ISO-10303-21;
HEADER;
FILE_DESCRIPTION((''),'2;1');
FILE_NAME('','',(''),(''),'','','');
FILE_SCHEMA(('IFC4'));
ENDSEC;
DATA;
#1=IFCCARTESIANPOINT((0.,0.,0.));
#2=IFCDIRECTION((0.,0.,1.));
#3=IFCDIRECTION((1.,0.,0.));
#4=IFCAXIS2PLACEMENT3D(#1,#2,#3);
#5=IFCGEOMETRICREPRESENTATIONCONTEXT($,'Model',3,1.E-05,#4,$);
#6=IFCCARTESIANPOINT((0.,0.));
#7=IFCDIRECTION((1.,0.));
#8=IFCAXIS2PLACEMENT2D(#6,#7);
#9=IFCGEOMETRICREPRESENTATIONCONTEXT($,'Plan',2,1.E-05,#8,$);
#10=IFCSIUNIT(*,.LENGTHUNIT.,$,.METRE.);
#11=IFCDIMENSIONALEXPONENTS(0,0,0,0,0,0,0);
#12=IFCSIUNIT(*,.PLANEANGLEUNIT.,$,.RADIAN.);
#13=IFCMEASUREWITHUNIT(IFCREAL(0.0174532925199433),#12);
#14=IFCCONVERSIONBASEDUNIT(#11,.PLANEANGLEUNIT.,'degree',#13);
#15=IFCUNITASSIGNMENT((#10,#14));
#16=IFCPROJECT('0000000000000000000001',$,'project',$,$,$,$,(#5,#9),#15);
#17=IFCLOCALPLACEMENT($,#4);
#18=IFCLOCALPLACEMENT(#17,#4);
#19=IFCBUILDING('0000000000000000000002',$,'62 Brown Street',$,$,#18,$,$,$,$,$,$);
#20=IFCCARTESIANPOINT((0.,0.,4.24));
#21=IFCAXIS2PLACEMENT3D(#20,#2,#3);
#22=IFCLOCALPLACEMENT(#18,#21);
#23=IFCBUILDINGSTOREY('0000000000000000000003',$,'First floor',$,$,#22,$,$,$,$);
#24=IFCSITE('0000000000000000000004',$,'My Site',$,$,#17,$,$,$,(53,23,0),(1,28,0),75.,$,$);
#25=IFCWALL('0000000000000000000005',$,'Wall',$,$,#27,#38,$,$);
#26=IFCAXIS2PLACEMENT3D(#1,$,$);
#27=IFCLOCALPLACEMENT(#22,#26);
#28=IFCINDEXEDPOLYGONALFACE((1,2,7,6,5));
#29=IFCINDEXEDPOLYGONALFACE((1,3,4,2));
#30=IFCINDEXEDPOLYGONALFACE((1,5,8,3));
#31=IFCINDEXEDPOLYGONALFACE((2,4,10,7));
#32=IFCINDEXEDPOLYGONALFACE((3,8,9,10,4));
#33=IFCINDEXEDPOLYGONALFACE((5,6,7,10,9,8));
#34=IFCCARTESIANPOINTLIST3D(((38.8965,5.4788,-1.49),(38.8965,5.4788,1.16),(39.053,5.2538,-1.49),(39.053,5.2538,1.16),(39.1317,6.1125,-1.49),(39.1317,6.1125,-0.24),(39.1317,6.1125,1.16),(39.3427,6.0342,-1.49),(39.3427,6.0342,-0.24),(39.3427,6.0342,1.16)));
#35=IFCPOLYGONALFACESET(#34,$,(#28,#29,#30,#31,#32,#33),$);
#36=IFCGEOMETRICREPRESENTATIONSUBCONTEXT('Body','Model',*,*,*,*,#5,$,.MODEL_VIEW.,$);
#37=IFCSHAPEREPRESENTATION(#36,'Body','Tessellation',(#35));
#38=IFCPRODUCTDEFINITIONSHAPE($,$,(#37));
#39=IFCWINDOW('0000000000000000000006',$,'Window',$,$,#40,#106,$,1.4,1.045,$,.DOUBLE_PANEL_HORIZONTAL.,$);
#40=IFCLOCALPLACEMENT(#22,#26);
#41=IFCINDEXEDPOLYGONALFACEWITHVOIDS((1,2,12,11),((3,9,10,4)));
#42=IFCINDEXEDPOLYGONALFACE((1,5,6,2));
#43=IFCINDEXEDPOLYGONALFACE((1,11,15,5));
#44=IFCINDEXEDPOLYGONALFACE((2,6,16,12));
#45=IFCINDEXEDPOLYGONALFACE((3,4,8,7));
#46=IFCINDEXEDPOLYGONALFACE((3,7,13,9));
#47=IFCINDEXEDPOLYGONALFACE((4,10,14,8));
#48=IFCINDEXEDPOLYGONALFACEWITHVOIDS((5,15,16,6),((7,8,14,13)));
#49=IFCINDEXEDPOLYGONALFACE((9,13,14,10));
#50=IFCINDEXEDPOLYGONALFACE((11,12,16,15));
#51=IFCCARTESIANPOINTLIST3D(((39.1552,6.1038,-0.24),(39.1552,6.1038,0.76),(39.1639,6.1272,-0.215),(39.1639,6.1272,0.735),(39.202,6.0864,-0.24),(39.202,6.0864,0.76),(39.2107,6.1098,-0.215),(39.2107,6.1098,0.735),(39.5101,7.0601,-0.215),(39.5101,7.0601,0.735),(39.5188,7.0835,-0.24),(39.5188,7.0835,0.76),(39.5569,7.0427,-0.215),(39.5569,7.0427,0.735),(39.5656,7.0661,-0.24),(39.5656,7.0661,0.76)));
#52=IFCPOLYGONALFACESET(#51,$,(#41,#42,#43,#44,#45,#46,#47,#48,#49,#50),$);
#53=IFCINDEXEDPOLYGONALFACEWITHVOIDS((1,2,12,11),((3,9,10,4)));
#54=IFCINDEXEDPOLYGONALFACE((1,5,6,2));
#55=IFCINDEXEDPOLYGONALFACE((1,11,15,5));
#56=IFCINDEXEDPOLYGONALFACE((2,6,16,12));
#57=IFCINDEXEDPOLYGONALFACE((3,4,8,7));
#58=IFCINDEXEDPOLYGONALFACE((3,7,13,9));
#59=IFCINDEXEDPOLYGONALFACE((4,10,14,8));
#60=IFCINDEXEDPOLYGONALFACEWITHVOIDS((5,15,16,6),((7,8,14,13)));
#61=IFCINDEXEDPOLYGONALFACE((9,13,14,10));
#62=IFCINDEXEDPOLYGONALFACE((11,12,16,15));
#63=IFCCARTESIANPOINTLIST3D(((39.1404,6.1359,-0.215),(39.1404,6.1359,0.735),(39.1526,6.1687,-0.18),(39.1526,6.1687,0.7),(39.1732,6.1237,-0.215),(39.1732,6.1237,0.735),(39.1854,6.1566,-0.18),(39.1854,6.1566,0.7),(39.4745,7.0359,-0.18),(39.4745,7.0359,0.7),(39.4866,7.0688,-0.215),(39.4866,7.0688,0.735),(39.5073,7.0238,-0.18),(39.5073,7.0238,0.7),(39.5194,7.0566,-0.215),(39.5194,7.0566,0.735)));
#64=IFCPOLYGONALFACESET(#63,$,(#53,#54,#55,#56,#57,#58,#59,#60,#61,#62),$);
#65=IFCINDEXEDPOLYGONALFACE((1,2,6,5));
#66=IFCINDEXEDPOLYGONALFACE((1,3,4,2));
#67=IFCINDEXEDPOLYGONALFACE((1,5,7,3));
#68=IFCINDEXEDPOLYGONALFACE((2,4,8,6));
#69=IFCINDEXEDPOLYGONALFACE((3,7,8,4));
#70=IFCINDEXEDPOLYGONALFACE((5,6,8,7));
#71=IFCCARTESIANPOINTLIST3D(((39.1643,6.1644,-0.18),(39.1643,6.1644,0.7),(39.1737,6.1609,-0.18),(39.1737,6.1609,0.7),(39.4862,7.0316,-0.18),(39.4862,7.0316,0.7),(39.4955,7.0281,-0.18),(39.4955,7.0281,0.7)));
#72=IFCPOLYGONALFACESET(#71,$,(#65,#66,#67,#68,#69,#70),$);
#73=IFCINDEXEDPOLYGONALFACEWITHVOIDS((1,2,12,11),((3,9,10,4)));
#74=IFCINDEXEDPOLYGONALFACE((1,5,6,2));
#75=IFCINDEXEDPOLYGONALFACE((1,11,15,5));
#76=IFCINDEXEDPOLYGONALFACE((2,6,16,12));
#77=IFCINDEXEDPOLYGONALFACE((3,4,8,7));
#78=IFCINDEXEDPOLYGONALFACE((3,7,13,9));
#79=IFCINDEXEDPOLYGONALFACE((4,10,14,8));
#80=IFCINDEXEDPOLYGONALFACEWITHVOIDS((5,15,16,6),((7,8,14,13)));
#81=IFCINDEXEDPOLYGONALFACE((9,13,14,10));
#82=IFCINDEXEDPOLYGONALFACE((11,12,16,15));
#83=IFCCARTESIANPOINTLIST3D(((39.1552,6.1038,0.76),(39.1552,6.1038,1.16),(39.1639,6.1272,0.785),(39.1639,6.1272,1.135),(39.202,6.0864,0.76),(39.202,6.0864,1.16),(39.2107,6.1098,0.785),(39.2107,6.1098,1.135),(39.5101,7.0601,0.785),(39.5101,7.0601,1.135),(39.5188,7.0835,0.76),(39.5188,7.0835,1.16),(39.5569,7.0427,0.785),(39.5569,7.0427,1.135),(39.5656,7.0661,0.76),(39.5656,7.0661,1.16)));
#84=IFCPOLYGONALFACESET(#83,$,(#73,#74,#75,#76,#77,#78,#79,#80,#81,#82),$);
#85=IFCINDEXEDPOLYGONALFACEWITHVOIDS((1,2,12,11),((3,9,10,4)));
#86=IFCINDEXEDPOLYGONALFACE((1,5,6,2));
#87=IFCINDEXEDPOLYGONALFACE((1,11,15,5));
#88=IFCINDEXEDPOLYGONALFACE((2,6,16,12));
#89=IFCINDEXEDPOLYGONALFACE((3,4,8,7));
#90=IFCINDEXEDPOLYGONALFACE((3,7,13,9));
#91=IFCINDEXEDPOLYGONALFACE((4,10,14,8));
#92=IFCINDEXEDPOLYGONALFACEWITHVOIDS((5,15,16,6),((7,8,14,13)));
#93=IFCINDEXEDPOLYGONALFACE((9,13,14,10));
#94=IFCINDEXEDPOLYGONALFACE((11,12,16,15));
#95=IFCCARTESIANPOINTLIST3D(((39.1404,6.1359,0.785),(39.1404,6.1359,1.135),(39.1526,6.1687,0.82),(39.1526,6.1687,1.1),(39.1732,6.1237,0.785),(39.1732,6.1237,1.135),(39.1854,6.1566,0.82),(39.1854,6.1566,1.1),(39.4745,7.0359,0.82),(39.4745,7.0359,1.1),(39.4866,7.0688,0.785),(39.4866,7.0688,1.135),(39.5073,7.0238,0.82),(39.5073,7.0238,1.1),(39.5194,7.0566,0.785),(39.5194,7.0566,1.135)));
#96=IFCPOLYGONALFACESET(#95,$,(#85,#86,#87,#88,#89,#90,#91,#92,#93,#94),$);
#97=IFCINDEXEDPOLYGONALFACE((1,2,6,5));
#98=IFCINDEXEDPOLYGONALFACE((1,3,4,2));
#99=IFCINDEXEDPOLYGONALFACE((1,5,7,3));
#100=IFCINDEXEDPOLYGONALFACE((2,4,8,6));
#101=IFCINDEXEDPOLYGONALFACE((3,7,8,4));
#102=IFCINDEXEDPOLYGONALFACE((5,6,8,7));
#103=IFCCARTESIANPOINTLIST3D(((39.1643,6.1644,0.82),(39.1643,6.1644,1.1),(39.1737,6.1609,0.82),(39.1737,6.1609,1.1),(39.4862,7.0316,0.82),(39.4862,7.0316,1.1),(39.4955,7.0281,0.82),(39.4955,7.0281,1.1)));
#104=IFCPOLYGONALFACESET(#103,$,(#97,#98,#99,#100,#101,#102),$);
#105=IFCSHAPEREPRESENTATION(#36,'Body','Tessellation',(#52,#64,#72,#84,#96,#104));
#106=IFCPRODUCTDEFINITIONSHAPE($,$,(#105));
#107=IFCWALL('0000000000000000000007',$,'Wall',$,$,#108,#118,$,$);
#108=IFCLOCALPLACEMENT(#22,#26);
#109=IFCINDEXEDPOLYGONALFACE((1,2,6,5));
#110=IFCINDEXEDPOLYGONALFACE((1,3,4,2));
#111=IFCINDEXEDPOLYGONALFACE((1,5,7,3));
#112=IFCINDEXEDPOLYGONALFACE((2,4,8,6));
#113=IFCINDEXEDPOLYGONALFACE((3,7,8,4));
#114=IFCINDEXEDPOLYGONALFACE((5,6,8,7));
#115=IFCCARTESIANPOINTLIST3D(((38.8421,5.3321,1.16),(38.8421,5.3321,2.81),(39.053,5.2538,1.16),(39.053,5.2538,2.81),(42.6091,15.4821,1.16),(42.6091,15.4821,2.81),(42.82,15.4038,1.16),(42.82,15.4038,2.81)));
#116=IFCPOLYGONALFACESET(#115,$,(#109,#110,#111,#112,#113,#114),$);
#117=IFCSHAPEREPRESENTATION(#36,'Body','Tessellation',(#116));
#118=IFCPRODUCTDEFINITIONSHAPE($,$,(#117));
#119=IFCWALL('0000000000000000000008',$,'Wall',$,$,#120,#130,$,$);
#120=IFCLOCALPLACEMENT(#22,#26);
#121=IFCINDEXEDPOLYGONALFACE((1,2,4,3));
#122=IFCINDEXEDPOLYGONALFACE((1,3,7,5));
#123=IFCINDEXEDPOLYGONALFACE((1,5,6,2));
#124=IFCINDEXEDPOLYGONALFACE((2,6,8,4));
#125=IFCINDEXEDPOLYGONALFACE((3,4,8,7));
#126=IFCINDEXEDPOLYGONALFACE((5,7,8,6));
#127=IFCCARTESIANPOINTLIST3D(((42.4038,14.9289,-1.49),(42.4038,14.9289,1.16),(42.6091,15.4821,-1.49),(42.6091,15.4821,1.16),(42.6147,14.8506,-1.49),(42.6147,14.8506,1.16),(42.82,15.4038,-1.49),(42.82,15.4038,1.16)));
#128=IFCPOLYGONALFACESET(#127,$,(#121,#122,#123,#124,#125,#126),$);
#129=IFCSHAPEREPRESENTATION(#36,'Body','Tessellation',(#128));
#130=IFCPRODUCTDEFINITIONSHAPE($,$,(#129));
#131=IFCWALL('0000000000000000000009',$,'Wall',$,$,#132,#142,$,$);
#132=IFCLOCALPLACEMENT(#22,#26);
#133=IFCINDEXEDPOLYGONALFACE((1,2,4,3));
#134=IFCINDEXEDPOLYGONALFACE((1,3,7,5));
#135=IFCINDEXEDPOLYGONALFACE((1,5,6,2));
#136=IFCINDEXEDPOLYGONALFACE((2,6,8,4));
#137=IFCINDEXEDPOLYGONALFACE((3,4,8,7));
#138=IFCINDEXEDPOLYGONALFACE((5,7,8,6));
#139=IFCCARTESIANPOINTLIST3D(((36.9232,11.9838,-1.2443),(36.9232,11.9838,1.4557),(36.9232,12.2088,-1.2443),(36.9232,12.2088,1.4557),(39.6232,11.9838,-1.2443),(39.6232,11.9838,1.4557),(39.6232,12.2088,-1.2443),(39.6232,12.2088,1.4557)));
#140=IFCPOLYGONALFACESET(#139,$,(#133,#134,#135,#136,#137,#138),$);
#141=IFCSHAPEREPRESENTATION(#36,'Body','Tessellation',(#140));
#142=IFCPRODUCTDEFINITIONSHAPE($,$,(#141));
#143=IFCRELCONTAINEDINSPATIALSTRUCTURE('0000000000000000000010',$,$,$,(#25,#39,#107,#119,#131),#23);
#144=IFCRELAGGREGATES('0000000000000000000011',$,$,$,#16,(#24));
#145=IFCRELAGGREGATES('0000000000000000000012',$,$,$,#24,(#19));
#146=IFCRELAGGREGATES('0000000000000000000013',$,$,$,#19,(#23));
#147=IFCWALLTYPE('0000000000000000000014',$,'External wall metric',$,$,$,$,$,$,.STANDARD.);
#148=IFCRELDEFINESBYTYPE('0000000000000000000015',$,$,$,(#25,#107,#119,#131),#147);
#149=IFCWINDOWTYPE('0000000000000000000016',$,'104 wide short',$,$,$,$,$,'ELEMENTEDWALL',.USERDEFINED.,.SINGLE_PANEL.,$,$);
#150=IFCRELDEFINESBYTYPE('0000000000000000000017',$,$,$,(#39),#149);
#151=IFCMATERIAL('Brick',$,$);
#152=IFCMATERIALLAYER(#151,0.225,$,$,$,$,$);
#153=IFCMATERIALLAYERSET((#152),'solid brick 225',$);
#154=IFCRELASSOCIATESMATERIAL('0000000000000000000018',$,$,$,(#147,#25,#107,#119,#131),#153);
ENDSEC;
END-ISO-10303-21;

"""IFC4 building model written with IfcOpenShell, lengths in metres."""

from ifc_helpers import new_model, entity, si_unit, converted_unit, frame, origin_with_axes, origin_2d_with_axis, place, context, subcontext, project, spatial, line, indexed_curve, outline, extrude, clip, halfspace, shape, source, transform, mapped, material, layer, layer_set, layer_usage, type_object, type_shapes, element, fill, save


model = new_model("IFC4")

# Units and contexts
model_context = context("Model", 3, precision=1e-05, world=origin_with_axes())
plan_context = context("Plan", 2, precision=1e-05, world=origin_2d_with_axis())
body_context_1 = subcontext(model_context, "Body", "Model", "MODEL_VIEW")
body_context_2 = subcontext(plan_context, "Body", "Plan", "PLAN_VIEW")
ifc_project = project(units=[si_unit("LENGTHUNIT", "METRE"), converted_unit("PLANEANGLEUNIT", "degree", entity("IfcReal", 0.0174532925199433), si_unit("PLANEANGLEUNIT", "RADIAN"), dimensions=[0, 0, 0, 0, 0, 0, 0])], contexts=[model_context, plan_context])

# Site, building, storey
site_placement = place(None, origin_with_axes())
site = spatial("IfcSite", under=ifc_project, at=site_placement, Name="My Site", RefLatitude=(53, 23, 0), RefLongitude=(1, 28, 0), RefElevation=75.0)
building_placement = place(site_placement, origin_with_axes())
building = spatial("IfcBuilding", under=site, at=building_placement, Name="62 Brown Street")
storey_placement = place(building_placement, frame((0.0, 0.0, 4.24), z_axis=(0.0, 0.0, 1.0), x_axis=(1.0, 0.0, 0.0)))
storey = spatial("IfcBuildingStorey", under=building, at=storey_placement, Name="First floor")

# Wall, opening, window
ifc_material_1 = material(Name="Brick")
ifc_layer_1 = layer(ifc_material_1, 0.225)
ifc_layer_set_1 = layer_set([ifc_layer_1], Name="solid brick 225")
ifc_layer_usage_1 = layer_usage(ifc_layer_set_1, "AXIS2", "POSITIVE", 0.0)
wall_type_1 = type_object("IfcWallType", Name="External wall metric", PredefinedType="STANDARD", material=ifc_layer_set_1)
wall_1_placement = place(storey_placement, frame((39.024, 5.1755, -1.49), z_axis=(0.0, 0.0, 1.0), x_axis=(0.347944, 0.937515, 0.0)))
wall_1 = element("IfcWall", 1, at=wall_1_placement, inside=storey, type_object=wall_type_1, material=ifc_layer_usage_1, Name="Wall", context=body_context_1, shape_type="Clipping", body=[
    clip(extrude(outline(indexed_curve([(0.0, 0.0), (0.0, 0.225), (0.9159, 0.225), (0.9159, 0.0), (0.0, 0.0)], self_intersect=False)), origin_with_axes(), (0.0, 0.0, 1.0), 2.65), halfspace(frame((0.0835, 0.0, -2.75), z_axis=(-0.596248, 0.414701, 0.0), x_axis=(0.156491, 0.224999, 0.0)), False)),
])
shared_shape_1 = source(origin_with_axes(), body_context_1, "Body", "SweptSolid", [
    extrude(outline(indexed_curve([(0.0, 0.0), (1.045, 0.0), (1.045, 1.4), (0.0, 1.4)], segments=[line(1, 2, 3, 4, 1)])), frame((0.0, -0.1, 0.0), z_axis=(0.0, -1.0, 0.0), x_axis=(1.0, 0.0, 0.0)), (0.0, 0.0, -1.0), 0.425),
])
opening_1_placement = place(wall_1_placement, frame((0.9159, 0.0, 1.25), z_axis=(0.0, 0.0, 1.0), x_axis=(1.0, 0.0, 0.0)))
opening_1 = element("IfcOpeningElement", 2, at=opening_1_placement, cuts=wall_1, PredefinedType="OPENING", context=body_context_1, shape_type="MappedRepresentation", body=[
    mapped(shared_shape_1, transform((0.0, 0.0, 0.0), x_axis=(1.0, 0.0, 0.0), y_axis=(0.0, 1.0, 0.0), z_axis=(0.0, 0.0, 1.0), scale=1.0)),
])
window_type_1 = type_object("IfcWindowType", Name="104 wide short", ElementType="ELEMENTEDWALL", PartitioningType="SINGLE_PANEL", PredefinedType="USERDEFINED")
shared_shape_2 = source(origin_with_axes(), body_context_1, "Body", "SweptSolid", [
    extrude(outline(indexed_curve([(0.0, 0.0), (1.045, 0.0), (1.045, 1.0), (0.0, 1.0)], segments=[line(1, 2, 3, 4, 1)]), holes=[indexed_curve([(0.025, 0.025), (1.02, 0.025), (1.02, 0.975), (0.025, 0.975)], segments=[line(1, 2, 3, 4, 1)])]), frame((0.0, 0.15, 0.0), z_axis=(0.0, -1.0, 0.0), x_axis=(1.0, 0.0, 0.0)), (0.0, 0.0, -1.0), 0.05),
    extrude(outline(indexed_curve([(0.0, 0.0), (0.995, 0.0), (0.995, 0.95), (0.0, 0.95)], segments=[line(1, 2, 3, 4, 1)]), holes=[indexed_curve([(0.035, 0.035), (0.96, 0.035), (0.96, 0.915), (0.035, 0.915)], segments=[line(1, 2, 3, 4, 1)])]), frame((0.025, 0.19, 0.025), z_axis=(0.0, -1.0, 0.0), x_axis=(1.0, 0.0, 0.0)), (0.0, 0.0, -1.0), 0.035),
    extrude(outline(indexed_curve([(0.035, 0.035), (0.96, 0.035), (0.96, 0.915), (0.035, 0.915)], segments=[line(1, 2, 3, 4, 1)])), frame((0.025, 0.2025, 0.025), z_axis=(0.0, -1.0, 0.0), x_axis=(1.0, 0.0, 0.0)), (0.0, 0.0, -1.0), 0.01),
    extrude(outline(indexed_curve([(0.0, 0.0), (1.045, 0.0), (1.045, 0.4), (0.0, 0.4)], segments=[line(1, 2, 3, 4, 1)]), holes=[indexed_curve([(0.025, 0.025), (1.02, 0.025), (1.02, 0.375), (0.025, 0.375)], segments=[line(1, 2, 3, 4, 1)])]), frame((0.0, 0.15, 1.0), z_axis=(0.0, -1.0, 0.0), x_axis=(1.0, 0.0, 0.0)), (0.0, 0.0, -1.0), 0.05),
    extrude(outline(indexed_curve([(0.0, 0.0), (0.995, 0.0), (0.995, 0.35), (0.0, 0.35)], segments=[line(1, 2, 3, 4, 1)]), holes=[indexed_curve([(0.035, 0.035), (0.96, 0.035), (0.96, 0.315), (0.035, 0.315)], segments=[line(1, 2, 3, 4, 1)])]), frame((0.025, 0.19, 1.025), z_axis=(0.0, -1.0, 0.0), x_axis=(1.0, 0.0, 0.0)), (0.0, 0.0, -1.0), 0.035),
    extrude(outline(indexed_curve([(0.035, 0.035), (0.96, 0.035), (0.96, 0.315), (0.035, 0.315)], segments=[line(1, 2, 3, 4, 1)])), frame((0.025, 0.2025, 1.025), z_axis=(0.0, -1.0, 0.0), x_axis=(1.0, 0.0, 0.0)), (0.0, 0.0, -1.0), 0.01),
])
shared_shape_3 = source(origin_with_axes(), body_context_2, "Body", "Curve2D", [
    entity("IfcIndexedPolyCurve", entity("IfcCartesianPointList2D", [[0.025, 0.15], [1.02, 0.15]])),
    entity("IfcIndexedPolyCurve", entity("IfcCartesianPointList2D", [[0.0, 0.2], [0.025, 0.2], [0.025, 0.15], [0.0, 0.15]]), [entity("IfcLineIndex", [1, 2, 3, 4, 1])]),
    entity("IfcIndexedPolyCurve", entity("IfcCartesianPointList2D", [[1.045, 0.2], [1.02, 0.2], [1.02, 0.15], [1.045, 0.15]]), [entity("IfcLineIndex", [1, 2, 3, 4, 1])]),
    entity("IfcIndexedPolyCurve", entity("IfcCartesianPointList2D", [[0.025, 0.19], [0.06, 0.19], [0.06, 0.225], [0.025, 0.225]]), [entity("IfcLineIndex", [1, 2, 3, 4, 1])]),
    entity("IfcIndexedPolyCurve", entity("IfcCartesianPointList2D", [[1.02, 0.19], [0.985, 0.19], [0.985, 0.225], [1.02, 0.225]]), [entity("IfcLineIndex", [1, 2, 3, 4, 1])]),
    entity("IfcIndexedPolyCurve", entity("IfcCartesianPointList2D", [[0.06, 0.19], [0.985, 0.19]])),
    entity("IfcIndexedPolyCurve", entity("IfcCartesianPointList2D", [[0.06, 0.225], [0.985, 0.225]])),
    entity("IfcIndexedPolyCurve", entity("IfcCartesianPointList2D", [[0.06, 0.2075], [0.985, 0.2075]])),
])
type_shapes(window_type_1, [shared_shape_2, shared_shape_3])
window_1_placement = place(opening_1_placement, frame((0.0, 0.0, 0.0), z_axis=(0.0, 0.0, 1.0), x_axis=(1.0, 0.0, 0.0)))
window_1 = element("IfcWindow", 3, at=window_1_placement, inside=storey, type_object=window_type_1, Name="Window", OverallHeight=1.4, OverallWidth=1.045, PartitioningType="DOUBLE_PANEL_HORIZONTAL", shapes=[
    shape(body_context_1, "Body", "MappedRepresentation", [mapped(shared_shape_2, transform((0.0, 0.0, 0.0), x_axis=(1.0, 0.0, 0.0), y_axis=(0.0, 1.0, 0.0), z_axis=(0.0, 0.0, 1.0), scale=1.0))]),
    shape(body_context_2, "Body", "MappedRepresentation", [mapped(shared_shape_3, transform((0.0, 0.0, 0.0), x_axis=(1.0, 0.0, 0.0), y_axis=(0.0, 1.0, 0.0), z_axis=(0.0, 0.0, 1.0), scale=1.0))]),
])
fill(opening_1, window_1)

# Walls
ifc_layer_usage_2 = layer_usage(ifc_layer_set_1, "AXIS2", "POSITIVE", 0.0)
wall_2_placement = place(storey_placement, frame((39.053, 5.2538, 1.16), z_axis=(0.0, 0.0, 1.0), x_axis=(0.347944, 0.937515, 0.0)))
element("IfcWall", 4, at=wall_2_placement, inside=storey, type_object=wall_type_1, material=ifc_layer_usage_2, Name="Wall", context=body_context_1, shape_type="SweptSolid", body=[
    extrude(outline(indexed_curve([(0.0, 0.0), (0.0, 0.225), (10.8265, 0.225), (10.8265, 0.0), (0.0, 0.0)], self_intersect=False)), origin_with_axes(), (0.0, 0.0, 1.0), 1.65),
])
ifc_layer_usage_3 = layer_usage(ifc_layer_set_1, "AXIS2", "POSITIVE", 0.0)
wall_3_placement = place(storey_placement, frame((42.6147, 14.8506, -1.49), z_axis=(0.0, 0.0, 1.0), x_axis=(0.347944, 0.937515, 0.0)))
element("IfcWall", 5, at=wall_3_placement, inside=storey, type_object=wall_type_1, material=ifc_layer_usage_3, Name="Wall", context=body_context_1, shape_type="SweptSolid", body=[
    extrude(outline(indexed_curve([(0.0, 0.0), (0.0, 0.225), (0.5901, 0.225), (0.5901, 0.0), (0.0, 0.0)], self_intersect=False)), origin_with_axes(), (0.0, 0.0, 1.0), 2.65),
])
ifc_layer_usage_4 = layer_usage(ifc_layer_set_1, "AXIS2", "POSITIVE", 0.0)
wall_4_placement = place(storey_placement, frame((36.9232, 11.9838, -1.2443), z_axis=(0.0, 0.0, 1.0), x_axis=(1.0, 0.0, 0.0)))
element("IfcWall", 6, at=wall_4_placement, inside=storey, type_object=wall_type_1, material=ifc_layer_usage_4, Name="Wall", context=body_context_1, shape_type="SweptSolid", body=[
    extrude(outline(indexed_curve([(0.0, 0.0), (0.0, 0.225), (2.7, 0.225), (2.7, 0.0), (0.0, 0.0)], self_intersect=False)), origin_with_axes(), (0.0, 0.0, 1.0), 2.7),
])

save(model, "model.ifc")
